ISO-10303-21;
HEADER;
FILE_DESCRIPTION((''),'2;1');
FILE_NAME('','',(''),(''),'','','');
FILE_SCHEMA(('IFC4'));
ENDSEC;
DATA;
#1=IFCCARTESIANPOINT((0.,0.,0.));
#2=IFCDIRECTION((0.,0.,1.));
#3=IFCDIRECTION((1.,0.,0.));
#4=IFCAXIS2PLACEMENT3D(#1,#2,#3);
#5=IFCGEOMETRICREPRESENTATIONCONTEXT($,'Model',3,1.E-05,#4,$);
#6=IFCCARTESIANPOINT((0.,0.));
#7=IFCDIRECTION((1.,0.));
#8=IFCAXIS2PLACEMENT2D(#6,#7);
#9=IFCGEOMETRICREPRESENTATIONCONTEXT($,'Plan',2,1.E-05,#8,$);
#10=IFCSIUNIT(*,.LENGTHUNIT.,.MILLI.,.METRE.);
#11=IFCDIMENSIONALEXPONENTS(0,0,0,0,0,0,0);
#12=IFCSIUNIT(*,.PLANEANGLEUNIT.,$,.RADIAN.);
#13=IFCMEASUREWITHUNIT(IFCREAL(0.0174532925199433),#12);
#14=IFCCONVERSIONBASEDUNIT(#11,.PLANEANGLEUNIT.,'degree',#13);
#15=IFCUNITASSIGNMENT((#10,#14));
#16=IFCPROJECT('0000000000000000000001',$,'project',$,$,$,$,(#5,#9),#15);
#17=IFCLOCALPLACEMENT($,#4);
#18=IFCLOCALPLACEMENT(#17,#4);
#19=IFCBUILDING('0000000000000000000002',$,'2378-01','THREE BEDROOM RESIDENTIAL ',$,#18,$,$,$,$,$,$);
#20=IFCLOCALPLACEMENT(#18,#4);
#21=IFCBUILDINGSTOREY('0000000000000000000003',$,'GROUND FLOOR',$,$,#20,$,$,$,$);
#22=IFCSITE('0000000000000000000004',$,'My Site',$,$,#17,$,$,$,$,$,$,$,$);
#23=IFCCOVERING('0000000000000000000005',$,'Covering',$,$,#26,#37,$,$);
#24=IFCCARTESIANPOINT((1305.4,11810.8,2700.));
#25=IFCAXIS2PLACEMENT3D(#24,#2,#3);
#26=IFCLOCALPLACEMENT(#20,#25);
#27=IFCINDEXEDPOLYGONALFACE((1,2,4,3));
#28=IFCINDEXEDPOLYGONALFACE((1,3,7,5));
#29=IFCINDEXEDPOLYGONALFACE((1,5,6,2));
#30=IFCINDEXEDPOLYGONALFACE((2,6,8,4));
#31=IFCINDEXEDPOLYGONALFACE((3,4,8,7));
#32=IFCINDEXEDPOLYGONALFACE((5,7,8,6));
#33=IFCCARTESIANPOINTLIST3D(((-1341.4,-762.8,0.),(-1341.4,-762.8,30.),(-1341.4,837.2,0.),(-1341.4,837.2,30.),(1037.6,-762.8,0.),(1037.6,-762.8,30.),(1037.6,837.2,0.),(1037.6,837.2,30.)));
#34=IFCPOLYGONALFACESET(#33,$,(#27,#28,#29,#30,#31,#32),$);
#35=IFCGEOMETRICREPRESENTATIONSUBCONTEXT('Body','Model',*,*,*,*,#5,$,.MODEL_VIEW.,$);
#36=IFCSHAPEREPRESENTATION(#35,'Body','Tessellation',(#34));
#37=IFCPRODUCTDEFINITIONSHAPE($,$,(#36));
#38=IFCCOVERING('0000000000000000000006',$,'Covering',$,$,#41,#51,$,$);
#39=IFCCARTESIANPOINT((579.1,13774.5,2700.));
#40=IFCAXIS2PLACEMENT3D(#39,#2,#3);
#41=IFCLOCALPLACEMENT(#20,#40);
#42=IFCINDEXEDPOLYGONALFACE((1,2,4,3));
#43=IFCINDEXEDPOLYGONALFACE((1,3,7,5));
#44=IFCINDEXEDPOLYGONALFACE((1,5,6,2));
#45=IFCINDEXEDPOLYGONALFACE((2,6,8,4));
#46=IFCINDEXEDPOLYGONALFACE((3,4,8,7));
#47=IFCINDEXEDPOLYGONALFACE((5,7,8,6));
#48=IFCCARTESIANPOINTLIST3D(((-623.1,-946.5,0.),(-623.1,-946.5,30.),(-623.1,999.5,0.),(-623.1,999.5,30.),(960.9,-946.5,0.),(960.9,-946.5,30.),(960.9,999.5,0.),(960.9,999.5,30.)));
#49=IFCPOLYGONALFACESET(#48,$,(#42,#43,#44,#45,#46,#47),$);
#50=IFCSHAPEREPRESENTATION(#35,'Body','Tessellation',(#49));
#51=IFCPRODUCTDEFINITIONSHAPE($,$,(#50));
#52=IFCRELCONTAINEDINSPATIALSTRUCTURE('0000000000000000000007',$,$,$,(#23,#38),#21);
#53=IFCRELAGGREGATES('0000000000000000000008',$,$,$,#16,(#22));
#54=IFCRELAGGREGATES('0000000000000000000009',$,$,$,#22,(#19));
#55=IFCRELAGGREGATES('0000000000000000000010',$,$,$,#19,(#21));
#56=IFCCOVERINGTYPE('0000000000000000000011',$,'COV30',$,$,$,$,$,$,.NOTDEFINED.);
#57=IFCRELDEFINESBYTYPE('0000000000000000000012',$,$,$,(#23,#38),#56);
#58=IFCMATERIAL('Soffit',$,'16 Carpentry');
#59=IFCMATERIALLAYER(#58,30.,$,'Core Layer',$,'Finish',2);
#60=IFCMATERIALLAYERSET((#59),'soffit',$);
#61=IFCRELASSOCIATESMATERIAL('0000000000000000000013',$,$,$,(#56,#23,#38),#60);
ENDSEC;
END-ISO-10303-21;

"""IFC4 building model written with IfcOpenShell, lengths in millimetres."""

from ifc_helpers import new_model, entity, si_unit, converted_unit, frame, origin_with_axes, origin_2d_with_axis, place, context, subcontext, project, spatial, line, indexed_curve, outline, extrude, material, layer, layer_set, layer_usage, type_object, element, save


model = new_model("IFC4")

# Units and contexts
model_context = context("Model", 3, precision=1e-05, world=origin_with_axes())
plan_context = context("Plan", 2, precision=1e-05, world=origin_2d_with_axis())
body_context_1 = subcontext(model_context, "Body", "Model", "MODEL_VIEW")
ifc_project = project(units=[si_unit("LENGTHUNIT", "METRE", prefix="MILLI"), converted_unit("PLANEANGLEUNIT", "degree", entity("IfcReal", 0.0174532925199433), si_unit("PLANEANGLEUNIT", "RADIAN"), dimensions=[0, 0, 0, 0, 0, 0, 0])], contexts=[model_context, plan_context])

# Site, building, storey
site_placement = place(None, origin_with_axes())
site = spatial("IfcSite", under=ifc_project, at=site_placement, Name="My Site")
building_placement = place(site_placement, origin_with_axes())
building = spatial("IfcBuilding", under=site, at=building_placement, Name="2378-01", Description="THREE BEDROOM RESIDENTIAL ")
storey_placement = place(building_placement, origin_with_axes())
storey = spatial("IfcBuildingStorey", under=building, at=storey_placement, Name="GROUND FLOOR")

# Coverings
ifc_material_1 = material(Name="Soffit", Category="16 Carpentry")
ifc_layer_1 = layer(ifc_material_1, 30.0, Name="Core Layer", Category="Finish", Priority=2)
ifc_layer_set_1 = layer_set([ifc_layer_1], Name="soffit")
ifc_layer_usage_1 = layer_usage(ifc_layer_set_1, "AXIS3", "POSITIVE", 0.0)
covering_type = type_object("IfcCoveringType", Name="COV30", PredefinedType="NOTDEFINED", material=ifc_layer_set_1)
covering_1_placement = place(storey_placement, frame((1305.4, 11810.8, 2700.0), z_axis=(0.0, 0.0, 1.0), x_axis=(1.0, 0.0, 0.0)))
element("IfcCovering", 1, at=covering_1_placement, inside=storey, type_object=covering_type, material=ifc_layer_usage_1, Name="Covering", context=body_context_1, shape_type="SweptSolid", body=[
    extrude(outline(indexed_curve([(-1341.4, -762.8), (-1341.4, 837.2), (1037.6, 837.2), (1037.6, -762.8), (-1341.4, -762.8)], segments=[line(1, 2, 3, 4, 5, 1)])), None, (0.0, 0.0, 1.0), 30.0),
])
ifc_layer_usage_2 = layer_usage(ifc_layer_set_1, "AXIS3", "POSITIVE", 0.0)
covering_2_placement = place(storey_placement, frame((579.1, 13774.5, 2700.0), z_axis=(0.0, 0.0, 1.0), x_axis=(1.0, 0.0, 0.0)))
element("IfcCovering", 2, at=covering_2_placement, inside=storey, type_object=covering_type, material=ifc_layer_usage_2, Name="Covering", context=body_context_1, shape_type="SweptSolid", body=[
    extrude(outline(indexed_curve([(960.9, 999.5), (960.9, -946.5), (-623.1, -946.5), (-623.1, 999.5), (960.9, 999.5)], segments=[line(1, 2, 3, 4, 5, 1)])), None, (0.0, 0.0, 1.0), 30.0),
])

save(model, "model.ifc")
